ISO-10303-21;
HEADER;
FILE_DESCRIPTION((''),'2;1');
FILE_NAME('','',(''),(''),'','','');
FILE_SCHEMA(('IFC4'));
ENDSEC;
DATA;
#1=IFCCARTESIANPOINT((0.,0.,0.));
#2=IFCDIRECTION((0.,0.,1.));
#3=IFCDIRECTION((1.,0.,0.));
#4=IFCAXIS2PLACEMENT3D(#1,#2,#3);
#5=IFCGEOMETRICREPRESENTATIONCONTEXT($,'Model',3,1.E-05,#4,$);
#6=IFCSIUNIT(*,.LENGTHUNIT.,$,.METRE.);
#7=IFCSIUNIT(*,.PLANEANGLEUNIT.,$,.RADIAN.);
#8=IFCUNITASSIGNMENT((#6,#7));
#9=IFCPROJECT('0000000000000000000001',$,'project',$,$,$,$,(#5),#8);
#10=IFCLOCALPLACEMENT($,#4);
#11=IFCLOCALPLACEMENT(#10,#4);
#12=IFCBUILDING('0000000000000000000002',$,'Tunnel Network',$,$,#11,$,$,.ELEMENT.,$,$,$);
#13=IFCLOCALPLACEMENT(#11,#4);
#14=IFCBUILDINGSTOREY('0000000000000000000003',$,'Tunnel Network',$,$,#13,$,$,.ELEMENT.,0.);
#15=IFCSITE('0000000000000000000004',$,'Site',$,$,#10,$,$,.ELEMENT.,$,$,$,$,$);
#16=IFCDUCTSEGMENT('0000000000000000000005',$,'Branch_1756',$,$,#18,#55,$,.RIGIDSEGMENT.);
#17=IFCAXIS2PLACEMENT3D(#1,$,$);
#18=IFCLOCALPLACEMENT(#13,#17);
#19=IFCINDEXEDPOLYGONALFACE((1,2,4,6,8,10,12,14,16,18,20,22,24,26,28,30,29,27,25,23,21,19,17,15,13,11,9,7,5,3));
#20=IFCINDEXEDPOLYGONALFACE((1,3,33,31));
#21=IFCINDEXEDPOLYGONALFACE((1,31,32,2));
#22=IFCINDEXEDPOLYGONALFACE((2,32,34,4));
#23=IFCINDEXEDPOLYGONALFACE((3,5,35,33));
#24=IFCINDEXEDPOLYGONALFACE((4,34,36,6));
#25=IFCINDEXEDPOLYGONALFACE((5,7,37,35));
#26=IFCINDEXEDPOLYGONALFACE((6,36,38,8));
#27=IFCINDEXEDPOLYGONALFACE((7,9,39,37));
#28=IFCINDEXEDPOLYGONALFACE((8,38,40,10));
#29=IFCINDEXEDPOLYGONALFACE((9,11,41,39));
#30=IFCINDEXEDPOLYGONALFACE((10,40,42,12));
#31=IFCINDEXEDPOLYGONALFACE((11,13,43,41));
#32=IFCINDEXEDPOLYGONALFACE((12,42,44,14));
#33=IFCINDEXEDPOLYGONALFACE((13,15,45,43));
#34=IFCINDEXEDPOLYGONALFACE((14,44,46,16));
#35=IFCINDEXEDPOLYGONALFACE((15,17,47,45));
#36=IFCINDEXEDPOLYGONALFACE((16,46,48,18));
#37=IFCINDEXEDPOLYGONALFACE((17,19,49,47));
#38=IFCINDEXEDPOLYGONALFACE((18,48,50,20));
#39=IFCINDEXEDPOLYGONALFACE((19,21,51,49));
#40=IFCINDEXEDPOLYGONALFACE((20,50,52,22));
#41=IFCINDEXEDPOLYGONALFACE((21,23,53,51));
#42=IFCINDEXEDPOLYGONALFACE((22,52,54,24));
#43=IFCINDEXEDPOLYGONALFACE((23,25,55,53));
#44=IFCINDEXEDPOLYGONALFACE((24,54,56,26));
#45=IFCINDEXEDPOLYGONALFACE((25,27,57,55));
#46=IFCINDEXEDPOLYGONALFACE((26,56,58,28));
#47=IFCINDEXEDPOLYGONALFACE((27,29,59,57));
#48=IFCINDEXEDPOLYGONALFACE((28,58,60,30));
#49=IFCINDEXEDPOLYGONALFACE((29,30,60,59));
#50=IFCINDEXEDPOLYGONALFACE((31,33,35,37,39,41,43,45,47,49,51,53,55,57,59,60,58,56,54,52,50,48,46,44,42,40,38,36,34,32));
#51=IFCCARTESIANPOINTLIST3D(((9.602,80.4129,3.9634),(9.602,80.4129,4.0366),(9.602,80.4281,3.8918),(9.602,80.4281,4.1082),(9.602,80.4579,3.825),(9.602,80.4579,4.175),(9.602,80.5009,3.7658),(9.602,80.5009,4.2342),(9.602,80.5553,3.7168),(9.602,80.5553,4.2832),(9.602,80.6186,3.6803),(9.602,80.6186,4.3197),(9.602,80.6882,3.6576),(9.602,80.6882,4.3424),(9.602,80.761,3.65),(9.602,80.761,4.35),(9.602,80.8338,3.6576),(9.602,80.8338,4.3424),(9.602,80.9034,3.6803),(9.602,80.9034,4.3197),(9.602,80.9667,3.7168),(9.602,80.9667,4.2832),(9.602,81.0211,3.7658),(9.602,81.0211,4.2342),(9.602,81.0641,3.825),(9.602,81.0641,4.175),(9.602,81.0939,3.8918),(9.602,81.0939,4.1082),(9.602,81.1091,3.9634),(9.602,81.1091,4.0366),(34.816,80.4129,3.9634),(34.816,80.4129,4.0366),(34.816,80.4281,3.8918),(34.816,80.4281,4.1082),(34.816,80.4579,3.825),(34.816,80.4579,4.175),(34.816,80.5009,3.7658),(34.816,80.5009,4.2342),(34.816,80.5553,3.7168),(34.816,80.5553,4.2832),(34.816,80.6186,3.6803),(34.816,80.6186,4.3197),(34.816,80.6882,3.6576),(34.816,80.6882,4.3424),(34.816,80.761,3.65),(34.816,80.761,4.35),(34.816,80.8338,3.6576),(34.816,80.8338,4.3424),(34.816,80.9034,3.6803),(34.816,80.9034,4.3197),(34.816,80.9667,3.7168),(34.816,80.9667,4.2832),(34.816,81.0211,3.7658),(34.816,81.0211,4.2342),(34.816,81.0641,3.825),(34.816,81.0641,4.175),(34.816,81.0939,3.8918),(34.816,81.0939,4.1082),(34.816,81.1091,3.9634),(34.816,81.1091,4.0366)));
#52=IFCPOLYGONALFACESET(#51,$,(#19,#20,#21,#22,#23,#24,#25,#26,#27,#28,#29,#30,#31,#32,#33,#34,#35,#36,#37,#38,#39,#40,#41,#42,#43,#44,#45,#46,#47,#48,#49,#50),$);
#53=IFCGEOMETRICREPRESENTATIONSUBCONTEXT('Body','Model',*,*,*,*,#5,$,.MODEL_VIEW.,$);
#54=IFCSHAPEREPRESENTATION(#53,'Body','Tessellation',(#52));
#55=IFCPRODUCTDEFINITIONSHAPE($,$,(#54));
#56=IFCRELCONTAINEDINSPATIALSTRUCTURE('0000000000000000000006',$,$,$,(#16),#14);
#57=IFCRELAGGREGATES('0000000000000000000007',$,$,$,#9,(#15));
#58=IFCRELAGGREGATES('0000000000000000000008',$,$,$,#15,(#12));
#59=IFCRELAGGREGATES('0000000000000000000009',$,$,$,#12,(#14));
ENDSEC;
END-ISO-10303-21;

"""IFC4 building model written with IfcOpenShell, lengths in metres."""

from ifc_helpers import new_model, si_unit, frame, origin_with_axes, origin_2d_with_axis, place, context, subcontext, project, spatial, circle, extrude, element, save


model = new_model("IFC4")

# Units and contexts
model_context = context("Model", 3, precision=1e-05, world=origin_with_axes())
body_context = subcontext(model_context, "Body", "Model", "MODEL_VIEW")
ifc_project = project(units=[si_unit("LENGTHUNIT", "METRE"), si_unit("PLANEANGLEUNIT", "RADIAN")], contexts=[model_context])

# Site, building, storey
site_placement = place(None, origin_with_axes())
site = spatial("IfcSite", under=ifc_project, at=site_placement, Name="Site", CompositionType="ELEMENT")
building_placement = place(site_placement, origin_with_axes())
building = spatial("IfcBuilding", under=site, at=building_placement, Name="Tunnel Network", CompositionType="ELEMENT")
storey_placement = place(building_placement, origin_with_axes())
storey = spatial("IfcBuildingStorey", under=building, at=storey_placement, Name="Tunnel Network", CompositionType="ELEMENT", Elevation=0.0)

# Duct segment
duct_segment_1_placement = place(storey_placement, frame((34.816, 80.761, 4.0), z_axis=(-1.0, 0.0, 0.0), x_axis=(0.0, 0.0, 1.0)))
element("IfcDuctSegment", 1, at=duct_segment_1_placement, inside=storey, Name="Branch_1756", PredefinedType="RIGIDSEGMENT", context=body_context, shape_type="SweptSolid", body=[
    extrude(circle(Radius=0.35, at=origin_2d_with_axis()), origin_with_axes(), (0.0, 0.0, 1.0), 25.214),
])

save(model, "model.ifc")
